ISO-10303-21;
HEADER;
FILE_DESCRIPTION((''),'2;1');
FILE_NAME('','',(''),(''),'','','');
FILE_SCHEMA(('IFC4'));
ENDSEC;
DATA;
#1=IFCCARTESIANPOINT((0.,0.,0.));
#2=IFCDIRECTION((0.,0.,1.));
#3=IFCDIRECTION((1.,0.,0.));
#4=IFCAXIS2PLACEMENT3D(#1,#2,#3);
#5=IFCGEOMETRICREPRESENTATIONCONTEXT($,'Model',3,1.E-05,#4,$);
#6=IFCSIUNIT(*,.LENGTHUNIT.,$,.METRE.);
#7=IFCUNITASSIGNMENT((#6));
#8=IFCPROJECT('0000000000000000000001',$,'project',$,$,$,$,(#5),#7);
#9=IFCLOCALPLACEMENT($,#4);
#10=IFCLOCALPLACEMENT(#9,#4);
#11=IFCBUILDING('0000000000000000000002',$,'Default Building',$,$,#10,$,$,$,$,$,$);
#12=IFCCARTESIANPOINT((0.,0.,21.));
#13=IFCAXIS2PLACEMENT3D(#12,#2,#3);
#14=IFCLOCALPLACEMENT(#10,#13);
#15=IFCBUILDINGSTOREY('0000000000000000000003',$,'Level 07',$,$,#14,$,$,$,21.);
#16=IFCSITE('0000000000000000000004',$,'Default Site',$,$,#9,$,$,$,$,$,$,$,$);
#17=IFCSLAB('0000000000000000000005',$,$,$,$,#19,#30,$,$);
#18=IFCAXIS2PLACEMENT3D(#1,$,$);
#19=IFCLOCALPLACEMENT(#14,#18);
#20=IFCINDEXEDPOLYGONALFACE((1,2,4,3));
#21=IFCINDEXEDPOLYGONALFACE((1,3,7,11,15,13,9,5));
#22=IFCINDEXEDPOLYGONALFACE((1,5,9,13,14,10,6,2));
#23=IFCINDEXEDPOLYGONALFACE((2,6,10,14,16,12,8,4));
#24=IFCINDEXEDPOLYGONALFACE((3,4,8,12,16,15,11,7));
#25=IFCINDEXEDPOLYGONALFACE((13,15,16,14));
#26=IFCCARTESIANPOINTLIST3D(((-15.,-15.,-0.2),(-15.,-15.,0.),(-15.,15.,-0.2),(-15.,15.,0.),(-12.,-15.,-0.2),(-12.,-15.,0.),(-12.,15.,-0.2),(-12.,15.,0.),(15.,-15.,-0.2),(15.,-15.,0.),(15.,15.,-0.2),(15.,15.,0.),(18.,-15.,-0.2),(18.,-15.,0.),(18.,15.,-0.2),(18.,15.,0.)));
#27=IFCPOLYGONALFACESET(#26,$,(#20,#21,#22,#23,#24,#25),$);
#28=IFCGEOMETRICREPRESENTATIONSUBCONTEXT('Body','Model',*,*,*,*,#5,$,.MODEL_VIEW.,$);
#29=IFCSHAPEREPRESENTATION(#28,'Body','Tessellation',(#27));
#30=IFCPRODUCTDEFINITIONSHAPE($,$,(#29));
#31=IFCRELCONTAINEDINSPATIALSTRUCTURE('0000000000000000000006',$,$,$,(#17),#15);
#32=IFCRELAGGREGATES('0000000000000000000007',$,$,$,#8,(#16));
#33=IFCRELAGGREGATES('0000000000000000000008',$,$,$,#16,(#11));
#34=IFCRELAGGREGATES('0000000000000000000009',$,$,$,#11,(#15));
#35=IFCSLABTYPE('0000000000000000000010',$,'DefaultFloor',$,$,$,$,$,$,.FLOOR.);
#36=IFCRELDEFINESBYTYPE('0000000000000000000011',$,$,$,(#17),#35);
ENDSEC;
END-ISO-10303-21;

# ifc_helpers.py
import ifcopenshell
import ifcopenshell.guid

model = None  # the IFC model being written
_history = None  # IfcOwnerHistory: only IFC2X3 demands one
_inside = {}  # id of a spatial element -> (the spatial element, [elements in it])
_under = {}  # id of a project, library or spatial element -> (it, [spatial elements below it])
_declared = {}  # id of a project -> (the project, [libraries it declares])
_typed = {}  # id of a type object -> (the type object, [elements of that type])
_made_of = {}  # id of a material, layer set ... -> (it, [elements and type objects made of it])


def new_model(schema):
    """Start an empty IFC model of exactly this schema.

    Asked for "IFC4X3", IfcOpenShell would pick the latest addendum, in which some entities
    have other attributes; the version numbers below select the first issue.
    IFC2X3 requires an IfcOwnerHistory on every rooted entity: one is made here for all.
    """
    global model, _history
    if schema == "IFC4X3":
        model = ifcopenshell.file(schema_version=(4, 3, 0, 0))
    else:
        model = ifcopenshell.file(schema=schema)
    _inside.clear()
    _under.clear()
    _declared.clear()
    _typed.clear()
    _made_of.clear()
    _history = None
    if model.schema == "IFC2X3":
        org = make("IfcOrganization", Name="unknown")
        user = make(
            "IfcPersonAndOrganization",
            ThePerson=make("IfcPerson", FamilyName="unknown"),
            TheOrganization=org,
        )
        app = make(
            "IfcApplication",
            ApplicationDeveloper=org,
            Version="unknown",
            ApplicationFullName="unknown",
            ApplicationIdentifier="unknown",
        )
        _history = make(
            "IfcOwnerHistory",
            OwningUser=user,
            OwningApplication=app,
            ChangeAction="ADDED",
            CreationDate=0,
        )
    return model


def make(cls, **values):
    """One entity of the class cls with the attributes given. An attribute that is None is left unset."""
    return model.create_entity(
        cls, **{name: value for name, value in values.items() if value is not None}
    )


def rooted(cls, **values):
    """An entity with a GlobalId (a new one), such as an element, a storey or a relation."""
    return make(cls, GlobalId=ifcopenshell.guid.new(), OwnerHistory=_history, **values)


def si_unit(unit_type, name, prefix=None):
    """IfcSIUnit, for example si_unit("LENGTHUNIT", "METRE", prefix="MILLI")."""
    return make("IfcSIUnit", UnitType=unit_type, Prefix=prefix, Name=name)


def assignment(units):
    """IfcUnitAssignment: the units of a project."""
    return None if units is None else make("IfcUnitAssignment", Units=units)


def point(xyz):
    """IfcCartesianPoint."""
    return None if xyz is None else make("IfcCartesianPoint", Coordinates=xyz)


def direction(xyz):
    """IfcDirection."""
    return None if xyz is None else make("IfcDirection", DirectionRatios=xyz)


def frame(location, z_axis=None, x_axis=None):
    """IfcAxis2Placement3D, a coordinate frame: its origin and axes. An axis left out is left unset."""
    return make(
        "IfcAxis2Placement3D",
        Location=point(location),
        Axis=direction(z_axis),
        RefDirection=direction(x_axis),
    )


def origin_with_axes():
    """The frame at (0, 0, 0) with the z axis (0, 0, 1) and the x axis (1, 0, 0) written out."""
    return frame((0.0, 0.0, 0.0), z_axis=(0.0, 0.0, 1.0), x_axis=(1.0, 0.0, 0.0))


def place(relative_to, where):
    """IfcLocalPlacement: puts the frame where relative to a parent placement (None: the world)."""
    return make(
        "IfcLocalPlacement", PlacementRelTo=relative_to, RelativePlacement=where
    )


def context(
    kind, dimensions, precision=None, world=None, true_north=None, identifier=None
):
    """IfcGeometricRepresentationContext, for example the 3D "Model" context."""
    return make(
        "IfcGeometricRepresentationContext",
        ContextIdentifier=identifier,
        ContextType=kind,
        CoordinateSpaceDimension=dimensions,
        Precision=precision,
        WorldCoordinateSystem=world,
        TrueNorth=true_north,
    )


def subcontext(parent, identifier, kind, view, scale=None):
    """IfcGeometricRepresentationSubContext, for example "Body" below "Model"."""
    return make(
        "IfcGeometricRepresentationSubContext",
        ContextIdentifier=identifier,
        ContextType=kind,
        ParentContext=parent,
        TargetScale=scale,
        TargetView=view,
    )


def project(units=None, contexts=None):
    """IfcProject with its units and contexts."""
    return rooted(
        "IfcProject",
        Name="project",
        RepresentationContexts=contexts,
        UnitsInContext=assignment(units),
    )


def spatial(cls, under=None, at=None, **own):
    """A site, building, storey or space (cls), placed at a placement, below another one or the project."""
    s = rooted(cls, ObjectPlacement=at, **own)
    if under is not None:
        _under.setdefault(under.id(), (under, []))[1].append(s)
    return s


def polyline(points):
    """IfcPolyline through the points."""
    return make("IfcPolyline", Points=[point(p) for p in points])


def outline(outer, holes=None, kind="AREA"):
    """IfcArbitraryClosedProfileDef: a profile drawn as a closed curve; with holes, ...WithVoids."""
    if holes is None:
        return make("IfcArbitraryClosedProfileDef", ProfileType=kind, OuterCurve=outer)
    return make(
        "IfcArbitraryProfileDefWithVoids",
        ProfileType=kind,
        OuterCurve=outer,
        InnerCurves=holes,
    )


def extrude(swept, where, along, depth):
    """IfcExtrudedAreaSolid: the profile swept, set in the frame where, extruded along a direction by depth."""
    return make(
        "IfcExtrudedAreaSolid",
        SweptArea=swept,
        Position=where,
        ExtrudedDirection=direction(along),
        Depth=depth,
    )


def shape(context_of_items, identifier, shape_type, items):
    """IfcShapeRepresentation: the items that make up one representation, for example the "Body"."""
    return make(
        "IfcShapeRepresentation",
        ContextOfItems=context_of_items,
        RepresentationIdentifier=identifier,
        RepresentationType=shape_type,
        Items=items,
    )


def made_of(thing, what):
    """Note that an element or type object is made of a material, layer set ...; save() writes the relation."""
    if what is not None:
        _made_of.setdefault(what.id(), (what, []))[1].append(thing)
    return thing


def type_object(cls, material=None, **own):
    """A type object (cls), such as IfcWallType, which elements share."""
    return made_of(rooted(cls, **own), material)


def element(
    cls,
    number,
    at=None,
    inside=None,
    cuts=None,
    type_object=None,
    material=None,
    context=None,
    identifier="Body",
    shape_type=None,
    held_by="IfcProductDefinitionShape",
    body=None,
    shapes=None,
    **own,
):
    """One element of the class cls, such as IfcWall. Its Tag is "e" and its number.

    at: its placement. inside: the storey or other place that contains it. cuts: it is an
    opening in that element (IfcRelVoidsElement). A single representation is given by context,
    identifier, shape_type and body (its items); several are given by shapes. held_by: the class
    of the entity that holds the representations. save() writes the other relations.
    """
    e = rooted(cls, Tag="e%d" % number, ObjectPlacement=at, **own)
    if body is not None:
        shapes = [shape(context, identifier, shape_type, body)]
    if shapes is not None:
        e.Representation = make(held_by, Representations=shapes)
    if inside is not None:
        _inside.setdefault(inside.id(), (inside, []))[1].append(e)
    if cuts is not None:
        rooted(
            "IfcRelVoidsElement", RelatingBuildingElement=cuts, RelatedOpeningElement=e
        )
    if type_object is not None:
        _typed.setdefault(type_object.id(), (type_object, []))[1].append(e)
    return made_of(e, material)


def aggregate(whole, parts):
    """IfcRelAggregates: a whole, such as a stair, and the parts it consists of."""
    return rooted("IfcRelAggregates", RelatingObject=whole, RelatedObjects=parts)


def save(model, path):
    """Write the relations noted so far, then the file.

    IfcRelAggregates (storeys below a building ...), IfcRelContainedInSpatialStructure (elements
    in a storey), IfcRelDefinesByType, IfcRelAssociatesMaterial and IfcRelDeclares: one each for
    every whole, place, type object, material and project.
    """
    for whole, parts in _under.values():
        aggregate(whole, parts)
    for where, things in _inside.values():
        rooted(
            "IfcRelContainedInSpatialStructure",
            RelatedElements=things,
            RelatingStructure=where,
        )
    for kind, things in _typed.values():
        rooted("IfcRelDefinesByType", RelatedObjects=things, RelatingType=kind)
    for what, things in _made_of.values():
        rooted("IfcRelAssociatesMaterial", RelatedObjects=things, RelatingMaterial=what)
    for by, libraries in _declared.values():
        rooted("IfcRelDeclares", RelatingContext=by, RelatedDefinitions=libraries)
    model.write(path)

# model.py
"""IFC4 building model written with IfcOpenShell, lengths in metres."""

from ifc_helpers import new_model, si_unit, frame, origin_with_axes, place, context, subcontext, project, spatial, polyline, outline, extrude, type_object, element, save


model = new_model("IFC4")

# Units and contexts
model_context = context("Model", 3, precision=1e-05, world=origin_with_axes())
body_context = subcontext(model_context, "Body", "Model", "MODEL_VIEW")
ifc_project = project(units=[si_unit("LENGTHUNIT", "METRE")], contexts=[model_context])

# Site, building, storey
site_placement = place(None, origin_with_axes())
site = spatial("IfcSite", under=ifc_project, at=site_placement, Name="Default Site")
building_placement = place(site_placement, origin_with_axes())
building = spatial("IfcBuilding", under=site, at=building_placement, Name="Default Building")
storey_placement = place(building_placement, frame((0.0, 0.0, 21.0), z_axis=(0.0, 0.0, 1.0), x_axis=(1.0, 0.0, 0.0)))
storey = spatial("IfcBuildingStorey", under=building, at=storey_placement, Name="Level 07", Elevation=21.0)

# Slab
slab_type = type_object("IfcSlabType", Name="DefaultFloor", PredefinedType="FLOOR")
slab_placement = place(storey_placement, frame((0.0, 0.0, -21.0), z_axis=(0.0, 0.0, 1.0), x_axis=(1.0, 0.0, 0.0)))
element("IfcSlab", 1, at=slab_placement, inside=storey, type_object=slab_type, context=body_context, shape_type="SweptSolid", body=[
    extrude(outline(polyline([(-15.0, -15.0), (-15.0, 15.0), (-12.0, 15.0), (15.0, 15.0), (18.0, 15.0), (18.0, -15.0), (15.0, -15.0), (-12.0, -15.0), (-15.0, -15.0)])), frame((0.0, 0.0, 21.0), z_axis=(0.0, 0.0, 1.0), x_axis=(1.0, 0.0, 0.0)), (0.0, 0.0, -1.0), 0.2),
])

save(model, "model.ifc")
